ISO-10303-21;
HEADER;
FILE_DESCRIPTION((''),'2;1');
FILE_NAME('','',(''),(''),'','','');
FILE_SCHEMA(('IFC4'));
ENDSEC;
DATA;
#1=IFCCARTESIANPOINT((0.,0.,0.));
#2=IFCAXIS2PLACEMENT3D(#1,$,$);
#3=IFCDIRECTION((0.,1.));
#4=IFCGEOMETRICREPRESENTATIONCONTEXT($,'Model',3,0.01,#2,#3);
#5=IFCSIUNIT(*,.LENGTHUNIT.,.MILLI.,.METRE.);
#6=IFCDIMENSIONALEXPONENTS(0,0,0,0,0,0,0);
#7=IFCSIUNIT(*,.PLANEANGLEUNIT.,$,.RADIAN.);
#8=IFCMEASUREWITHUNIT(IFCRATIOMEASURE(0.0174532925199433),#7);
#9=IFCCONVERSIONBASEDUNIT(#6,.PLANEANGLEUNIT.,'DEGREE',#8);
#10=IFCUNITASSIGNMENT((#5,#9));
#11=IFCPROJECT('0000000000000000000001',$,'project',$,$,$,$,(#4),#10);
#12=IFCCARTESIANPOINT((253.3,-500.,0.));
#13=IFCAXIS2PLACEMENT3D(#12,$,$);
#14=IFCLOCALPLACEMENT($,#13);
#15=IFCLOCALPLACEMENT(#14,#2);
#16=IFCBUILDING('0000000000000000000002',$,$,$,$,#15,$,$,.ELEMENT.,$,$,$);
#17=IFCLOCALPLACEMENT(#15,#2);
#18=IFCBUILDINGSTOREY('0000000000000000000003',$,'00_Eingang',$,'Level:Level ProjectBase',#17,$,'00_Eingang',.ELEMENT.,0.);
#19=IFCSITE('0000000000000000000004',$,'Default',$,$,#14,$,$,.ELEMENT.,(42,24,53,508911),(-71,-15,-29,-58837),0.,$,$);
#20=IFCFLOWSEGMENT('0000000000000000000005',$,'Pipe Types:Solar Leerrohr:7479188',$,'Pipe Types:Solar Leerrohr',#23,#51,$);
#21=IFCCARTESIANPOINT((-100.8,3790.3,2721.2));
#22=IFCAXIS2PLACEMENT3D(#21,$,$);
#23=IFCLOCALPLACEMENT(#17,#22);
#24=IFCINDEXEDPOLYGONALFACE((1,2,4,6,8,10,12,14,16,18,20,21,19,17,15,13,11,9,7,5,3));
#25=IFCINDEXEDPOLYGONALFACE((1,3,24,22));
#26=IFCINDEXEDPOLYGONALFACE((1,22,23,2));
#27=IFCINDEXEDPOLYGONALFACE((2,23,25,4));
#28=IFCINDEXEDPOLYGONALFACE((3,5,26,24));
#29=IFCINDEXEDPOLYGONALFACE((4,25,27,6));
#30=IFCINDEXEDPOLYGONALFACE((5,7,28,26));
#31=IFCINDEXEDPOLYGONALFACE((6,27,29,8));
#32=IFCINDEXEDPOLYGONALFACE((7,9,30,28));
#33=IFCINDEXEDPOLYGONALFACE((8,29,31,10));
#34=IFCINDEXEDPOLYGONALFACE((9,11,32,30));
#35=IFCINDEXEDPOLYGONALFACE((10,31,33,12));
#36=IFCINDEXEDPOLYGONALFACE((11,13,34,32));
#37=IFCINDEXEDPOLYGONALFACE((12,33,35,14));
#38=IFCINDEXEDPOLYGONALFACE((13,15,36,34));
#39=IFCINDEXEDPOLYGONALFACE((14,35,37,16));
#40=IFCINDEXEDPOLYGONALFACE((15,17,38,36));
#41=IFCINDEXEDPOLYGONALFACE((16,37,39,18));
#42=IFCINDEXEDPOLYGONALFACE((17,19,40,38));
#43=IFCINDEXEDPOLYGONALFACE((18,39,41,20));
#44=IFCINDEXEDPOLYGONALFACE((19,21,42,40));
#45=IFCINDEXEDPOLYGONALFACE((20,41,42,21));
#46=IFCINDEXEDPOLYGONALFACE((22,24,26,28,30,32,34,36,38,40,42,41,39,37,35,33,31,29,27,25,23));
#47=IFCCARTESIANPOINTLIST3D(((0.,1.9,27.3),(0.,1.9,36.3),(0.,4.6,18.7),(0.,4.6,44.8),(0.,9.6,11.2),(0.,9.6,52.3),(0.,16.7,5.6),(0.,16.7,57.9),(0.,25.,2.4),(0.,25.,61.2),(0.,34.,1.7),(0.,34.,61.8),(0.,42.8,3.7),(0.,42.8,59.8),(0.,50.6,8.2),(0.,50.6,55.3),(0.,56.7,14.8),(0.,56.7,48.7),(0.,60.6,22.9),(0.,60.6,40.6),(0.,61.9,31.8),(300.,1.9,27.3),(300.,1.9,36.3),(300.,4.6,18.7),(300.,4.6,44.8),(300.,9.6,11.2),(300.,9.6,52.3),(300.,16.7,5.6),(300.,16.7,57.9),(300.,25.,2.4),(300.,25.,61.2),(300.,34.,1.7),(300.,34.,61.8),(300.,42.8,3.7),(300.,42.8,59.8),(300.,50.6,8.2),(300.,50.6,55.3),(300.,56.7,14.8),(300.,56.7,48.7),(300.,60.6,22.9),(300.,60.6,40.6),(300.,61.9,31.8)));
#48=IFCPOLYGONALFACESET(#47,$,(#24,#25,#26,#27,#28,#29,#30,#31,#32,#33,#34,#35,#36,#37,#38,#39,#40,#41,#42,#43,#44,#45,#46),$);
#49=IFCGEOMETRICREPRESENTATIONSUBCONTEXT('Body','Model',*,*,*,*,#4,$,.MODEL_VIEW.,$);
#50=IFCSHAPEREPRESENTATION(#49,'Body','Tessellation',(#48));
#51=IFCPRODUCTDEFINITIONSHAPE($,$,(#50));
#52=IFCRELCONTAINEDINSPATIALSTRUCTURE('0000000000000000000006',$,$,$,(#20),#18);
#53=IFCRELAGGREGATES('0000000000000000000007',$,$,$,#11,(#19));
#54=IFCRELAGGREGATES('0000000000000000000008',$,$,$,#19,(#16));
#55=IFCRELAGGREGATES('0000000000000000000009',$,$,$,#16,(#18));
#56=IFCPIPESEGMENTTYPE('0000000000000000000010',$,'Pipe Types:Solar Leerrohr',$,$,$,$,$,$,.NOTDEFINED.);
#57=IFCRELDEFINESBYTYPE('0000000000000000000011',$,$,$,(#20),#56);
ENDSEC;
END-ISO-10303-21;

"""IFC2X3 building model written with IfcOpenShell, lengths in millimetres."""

from ifc_helpers import new_model, entity, si_unit, converted_unit, direction, frame, frame_2d, origin, place, context, subcontext, project, spatial, circle, extrude, type_object, element, save


model = new_model("IFC2X3")

# Units and contexts
model_context = context("Model", 3, precision=0.01, world=origin(), true_north=direction((0.0, 1.0)))
body_context = subcontext(model_context, "Body", "Model", "MODEL_VIEW")
ifc_project = project(units=[si_unit("LENGTHUNIT", "METRE", prefix="MILLI"), converted_unit("PLANEANGLEUNIT", "DEGREE", entity("IfcRatioMeasure", 0.0174532925199433), si_unit("PLANEANGLEUNIT", "RADIAN"), dimensions=[0, 0, 0, 0, 0, 0, 0])], contexts=[model_context])

# Site, building, storey
site_placement = place(None, frame((253.3, -500.0, 0.0)))
site = spatial("IfcSite", under=ifc_project, at=site_placement, Name="Default", CompositionType="ELEMENT", RefLatitude=(42, 24, 53, 508911), RefLongitude=(-71, -15, -29, -58837), RefElevation=0.0)
building_placement = place(site_placement, origin())
building = spatial("IfcBuilding", under=site, at=building_placement, CompositionType="ELEMENT")
storey_placement = place(building_placement, origin())
storey = spatial("IfcBuildingStorey", under=building, at=storey_placement, Name="00_Eingang", ObjectType="Level:Level ProjectBase", LongName="00_Eingang", CompositionType="ELEMENT", Elevation=0.0)

# Flow segment
pipe_segment_type_1 = type_object("IfcPipeSegmentType", Name="Pipe Types:Solar Leerrohr", PredefinedType="NOTDEFINED")
flow_segment_1_placement = place(storey_placement, frame((-100.8, 3790.3, 2721.2)))
element("IfcFlowSegment", 1, at=flow_segment_1_placement, inside=storey, type_object=pipe_segment_type_1, Name="Pipe Types:Solar Leerrohr:7479188", ObjectType="Pipe Types:Solar Leerrohr", context=body_context, shape_type="SweptSolid", body=[
    extrude(circle(Radius=30.2, at=frame_2d((0.0, 0.0), x_axis=(1.0, 0.0))), frame((0.0, 31.8, 31.8), z_axis=(1.0, 0.0, 0.0), x_axis=(0.0, 1.0, 0.0)), (0.0, 0.0, 1.0), 300.0),
])

save(model, "model.ifc")
